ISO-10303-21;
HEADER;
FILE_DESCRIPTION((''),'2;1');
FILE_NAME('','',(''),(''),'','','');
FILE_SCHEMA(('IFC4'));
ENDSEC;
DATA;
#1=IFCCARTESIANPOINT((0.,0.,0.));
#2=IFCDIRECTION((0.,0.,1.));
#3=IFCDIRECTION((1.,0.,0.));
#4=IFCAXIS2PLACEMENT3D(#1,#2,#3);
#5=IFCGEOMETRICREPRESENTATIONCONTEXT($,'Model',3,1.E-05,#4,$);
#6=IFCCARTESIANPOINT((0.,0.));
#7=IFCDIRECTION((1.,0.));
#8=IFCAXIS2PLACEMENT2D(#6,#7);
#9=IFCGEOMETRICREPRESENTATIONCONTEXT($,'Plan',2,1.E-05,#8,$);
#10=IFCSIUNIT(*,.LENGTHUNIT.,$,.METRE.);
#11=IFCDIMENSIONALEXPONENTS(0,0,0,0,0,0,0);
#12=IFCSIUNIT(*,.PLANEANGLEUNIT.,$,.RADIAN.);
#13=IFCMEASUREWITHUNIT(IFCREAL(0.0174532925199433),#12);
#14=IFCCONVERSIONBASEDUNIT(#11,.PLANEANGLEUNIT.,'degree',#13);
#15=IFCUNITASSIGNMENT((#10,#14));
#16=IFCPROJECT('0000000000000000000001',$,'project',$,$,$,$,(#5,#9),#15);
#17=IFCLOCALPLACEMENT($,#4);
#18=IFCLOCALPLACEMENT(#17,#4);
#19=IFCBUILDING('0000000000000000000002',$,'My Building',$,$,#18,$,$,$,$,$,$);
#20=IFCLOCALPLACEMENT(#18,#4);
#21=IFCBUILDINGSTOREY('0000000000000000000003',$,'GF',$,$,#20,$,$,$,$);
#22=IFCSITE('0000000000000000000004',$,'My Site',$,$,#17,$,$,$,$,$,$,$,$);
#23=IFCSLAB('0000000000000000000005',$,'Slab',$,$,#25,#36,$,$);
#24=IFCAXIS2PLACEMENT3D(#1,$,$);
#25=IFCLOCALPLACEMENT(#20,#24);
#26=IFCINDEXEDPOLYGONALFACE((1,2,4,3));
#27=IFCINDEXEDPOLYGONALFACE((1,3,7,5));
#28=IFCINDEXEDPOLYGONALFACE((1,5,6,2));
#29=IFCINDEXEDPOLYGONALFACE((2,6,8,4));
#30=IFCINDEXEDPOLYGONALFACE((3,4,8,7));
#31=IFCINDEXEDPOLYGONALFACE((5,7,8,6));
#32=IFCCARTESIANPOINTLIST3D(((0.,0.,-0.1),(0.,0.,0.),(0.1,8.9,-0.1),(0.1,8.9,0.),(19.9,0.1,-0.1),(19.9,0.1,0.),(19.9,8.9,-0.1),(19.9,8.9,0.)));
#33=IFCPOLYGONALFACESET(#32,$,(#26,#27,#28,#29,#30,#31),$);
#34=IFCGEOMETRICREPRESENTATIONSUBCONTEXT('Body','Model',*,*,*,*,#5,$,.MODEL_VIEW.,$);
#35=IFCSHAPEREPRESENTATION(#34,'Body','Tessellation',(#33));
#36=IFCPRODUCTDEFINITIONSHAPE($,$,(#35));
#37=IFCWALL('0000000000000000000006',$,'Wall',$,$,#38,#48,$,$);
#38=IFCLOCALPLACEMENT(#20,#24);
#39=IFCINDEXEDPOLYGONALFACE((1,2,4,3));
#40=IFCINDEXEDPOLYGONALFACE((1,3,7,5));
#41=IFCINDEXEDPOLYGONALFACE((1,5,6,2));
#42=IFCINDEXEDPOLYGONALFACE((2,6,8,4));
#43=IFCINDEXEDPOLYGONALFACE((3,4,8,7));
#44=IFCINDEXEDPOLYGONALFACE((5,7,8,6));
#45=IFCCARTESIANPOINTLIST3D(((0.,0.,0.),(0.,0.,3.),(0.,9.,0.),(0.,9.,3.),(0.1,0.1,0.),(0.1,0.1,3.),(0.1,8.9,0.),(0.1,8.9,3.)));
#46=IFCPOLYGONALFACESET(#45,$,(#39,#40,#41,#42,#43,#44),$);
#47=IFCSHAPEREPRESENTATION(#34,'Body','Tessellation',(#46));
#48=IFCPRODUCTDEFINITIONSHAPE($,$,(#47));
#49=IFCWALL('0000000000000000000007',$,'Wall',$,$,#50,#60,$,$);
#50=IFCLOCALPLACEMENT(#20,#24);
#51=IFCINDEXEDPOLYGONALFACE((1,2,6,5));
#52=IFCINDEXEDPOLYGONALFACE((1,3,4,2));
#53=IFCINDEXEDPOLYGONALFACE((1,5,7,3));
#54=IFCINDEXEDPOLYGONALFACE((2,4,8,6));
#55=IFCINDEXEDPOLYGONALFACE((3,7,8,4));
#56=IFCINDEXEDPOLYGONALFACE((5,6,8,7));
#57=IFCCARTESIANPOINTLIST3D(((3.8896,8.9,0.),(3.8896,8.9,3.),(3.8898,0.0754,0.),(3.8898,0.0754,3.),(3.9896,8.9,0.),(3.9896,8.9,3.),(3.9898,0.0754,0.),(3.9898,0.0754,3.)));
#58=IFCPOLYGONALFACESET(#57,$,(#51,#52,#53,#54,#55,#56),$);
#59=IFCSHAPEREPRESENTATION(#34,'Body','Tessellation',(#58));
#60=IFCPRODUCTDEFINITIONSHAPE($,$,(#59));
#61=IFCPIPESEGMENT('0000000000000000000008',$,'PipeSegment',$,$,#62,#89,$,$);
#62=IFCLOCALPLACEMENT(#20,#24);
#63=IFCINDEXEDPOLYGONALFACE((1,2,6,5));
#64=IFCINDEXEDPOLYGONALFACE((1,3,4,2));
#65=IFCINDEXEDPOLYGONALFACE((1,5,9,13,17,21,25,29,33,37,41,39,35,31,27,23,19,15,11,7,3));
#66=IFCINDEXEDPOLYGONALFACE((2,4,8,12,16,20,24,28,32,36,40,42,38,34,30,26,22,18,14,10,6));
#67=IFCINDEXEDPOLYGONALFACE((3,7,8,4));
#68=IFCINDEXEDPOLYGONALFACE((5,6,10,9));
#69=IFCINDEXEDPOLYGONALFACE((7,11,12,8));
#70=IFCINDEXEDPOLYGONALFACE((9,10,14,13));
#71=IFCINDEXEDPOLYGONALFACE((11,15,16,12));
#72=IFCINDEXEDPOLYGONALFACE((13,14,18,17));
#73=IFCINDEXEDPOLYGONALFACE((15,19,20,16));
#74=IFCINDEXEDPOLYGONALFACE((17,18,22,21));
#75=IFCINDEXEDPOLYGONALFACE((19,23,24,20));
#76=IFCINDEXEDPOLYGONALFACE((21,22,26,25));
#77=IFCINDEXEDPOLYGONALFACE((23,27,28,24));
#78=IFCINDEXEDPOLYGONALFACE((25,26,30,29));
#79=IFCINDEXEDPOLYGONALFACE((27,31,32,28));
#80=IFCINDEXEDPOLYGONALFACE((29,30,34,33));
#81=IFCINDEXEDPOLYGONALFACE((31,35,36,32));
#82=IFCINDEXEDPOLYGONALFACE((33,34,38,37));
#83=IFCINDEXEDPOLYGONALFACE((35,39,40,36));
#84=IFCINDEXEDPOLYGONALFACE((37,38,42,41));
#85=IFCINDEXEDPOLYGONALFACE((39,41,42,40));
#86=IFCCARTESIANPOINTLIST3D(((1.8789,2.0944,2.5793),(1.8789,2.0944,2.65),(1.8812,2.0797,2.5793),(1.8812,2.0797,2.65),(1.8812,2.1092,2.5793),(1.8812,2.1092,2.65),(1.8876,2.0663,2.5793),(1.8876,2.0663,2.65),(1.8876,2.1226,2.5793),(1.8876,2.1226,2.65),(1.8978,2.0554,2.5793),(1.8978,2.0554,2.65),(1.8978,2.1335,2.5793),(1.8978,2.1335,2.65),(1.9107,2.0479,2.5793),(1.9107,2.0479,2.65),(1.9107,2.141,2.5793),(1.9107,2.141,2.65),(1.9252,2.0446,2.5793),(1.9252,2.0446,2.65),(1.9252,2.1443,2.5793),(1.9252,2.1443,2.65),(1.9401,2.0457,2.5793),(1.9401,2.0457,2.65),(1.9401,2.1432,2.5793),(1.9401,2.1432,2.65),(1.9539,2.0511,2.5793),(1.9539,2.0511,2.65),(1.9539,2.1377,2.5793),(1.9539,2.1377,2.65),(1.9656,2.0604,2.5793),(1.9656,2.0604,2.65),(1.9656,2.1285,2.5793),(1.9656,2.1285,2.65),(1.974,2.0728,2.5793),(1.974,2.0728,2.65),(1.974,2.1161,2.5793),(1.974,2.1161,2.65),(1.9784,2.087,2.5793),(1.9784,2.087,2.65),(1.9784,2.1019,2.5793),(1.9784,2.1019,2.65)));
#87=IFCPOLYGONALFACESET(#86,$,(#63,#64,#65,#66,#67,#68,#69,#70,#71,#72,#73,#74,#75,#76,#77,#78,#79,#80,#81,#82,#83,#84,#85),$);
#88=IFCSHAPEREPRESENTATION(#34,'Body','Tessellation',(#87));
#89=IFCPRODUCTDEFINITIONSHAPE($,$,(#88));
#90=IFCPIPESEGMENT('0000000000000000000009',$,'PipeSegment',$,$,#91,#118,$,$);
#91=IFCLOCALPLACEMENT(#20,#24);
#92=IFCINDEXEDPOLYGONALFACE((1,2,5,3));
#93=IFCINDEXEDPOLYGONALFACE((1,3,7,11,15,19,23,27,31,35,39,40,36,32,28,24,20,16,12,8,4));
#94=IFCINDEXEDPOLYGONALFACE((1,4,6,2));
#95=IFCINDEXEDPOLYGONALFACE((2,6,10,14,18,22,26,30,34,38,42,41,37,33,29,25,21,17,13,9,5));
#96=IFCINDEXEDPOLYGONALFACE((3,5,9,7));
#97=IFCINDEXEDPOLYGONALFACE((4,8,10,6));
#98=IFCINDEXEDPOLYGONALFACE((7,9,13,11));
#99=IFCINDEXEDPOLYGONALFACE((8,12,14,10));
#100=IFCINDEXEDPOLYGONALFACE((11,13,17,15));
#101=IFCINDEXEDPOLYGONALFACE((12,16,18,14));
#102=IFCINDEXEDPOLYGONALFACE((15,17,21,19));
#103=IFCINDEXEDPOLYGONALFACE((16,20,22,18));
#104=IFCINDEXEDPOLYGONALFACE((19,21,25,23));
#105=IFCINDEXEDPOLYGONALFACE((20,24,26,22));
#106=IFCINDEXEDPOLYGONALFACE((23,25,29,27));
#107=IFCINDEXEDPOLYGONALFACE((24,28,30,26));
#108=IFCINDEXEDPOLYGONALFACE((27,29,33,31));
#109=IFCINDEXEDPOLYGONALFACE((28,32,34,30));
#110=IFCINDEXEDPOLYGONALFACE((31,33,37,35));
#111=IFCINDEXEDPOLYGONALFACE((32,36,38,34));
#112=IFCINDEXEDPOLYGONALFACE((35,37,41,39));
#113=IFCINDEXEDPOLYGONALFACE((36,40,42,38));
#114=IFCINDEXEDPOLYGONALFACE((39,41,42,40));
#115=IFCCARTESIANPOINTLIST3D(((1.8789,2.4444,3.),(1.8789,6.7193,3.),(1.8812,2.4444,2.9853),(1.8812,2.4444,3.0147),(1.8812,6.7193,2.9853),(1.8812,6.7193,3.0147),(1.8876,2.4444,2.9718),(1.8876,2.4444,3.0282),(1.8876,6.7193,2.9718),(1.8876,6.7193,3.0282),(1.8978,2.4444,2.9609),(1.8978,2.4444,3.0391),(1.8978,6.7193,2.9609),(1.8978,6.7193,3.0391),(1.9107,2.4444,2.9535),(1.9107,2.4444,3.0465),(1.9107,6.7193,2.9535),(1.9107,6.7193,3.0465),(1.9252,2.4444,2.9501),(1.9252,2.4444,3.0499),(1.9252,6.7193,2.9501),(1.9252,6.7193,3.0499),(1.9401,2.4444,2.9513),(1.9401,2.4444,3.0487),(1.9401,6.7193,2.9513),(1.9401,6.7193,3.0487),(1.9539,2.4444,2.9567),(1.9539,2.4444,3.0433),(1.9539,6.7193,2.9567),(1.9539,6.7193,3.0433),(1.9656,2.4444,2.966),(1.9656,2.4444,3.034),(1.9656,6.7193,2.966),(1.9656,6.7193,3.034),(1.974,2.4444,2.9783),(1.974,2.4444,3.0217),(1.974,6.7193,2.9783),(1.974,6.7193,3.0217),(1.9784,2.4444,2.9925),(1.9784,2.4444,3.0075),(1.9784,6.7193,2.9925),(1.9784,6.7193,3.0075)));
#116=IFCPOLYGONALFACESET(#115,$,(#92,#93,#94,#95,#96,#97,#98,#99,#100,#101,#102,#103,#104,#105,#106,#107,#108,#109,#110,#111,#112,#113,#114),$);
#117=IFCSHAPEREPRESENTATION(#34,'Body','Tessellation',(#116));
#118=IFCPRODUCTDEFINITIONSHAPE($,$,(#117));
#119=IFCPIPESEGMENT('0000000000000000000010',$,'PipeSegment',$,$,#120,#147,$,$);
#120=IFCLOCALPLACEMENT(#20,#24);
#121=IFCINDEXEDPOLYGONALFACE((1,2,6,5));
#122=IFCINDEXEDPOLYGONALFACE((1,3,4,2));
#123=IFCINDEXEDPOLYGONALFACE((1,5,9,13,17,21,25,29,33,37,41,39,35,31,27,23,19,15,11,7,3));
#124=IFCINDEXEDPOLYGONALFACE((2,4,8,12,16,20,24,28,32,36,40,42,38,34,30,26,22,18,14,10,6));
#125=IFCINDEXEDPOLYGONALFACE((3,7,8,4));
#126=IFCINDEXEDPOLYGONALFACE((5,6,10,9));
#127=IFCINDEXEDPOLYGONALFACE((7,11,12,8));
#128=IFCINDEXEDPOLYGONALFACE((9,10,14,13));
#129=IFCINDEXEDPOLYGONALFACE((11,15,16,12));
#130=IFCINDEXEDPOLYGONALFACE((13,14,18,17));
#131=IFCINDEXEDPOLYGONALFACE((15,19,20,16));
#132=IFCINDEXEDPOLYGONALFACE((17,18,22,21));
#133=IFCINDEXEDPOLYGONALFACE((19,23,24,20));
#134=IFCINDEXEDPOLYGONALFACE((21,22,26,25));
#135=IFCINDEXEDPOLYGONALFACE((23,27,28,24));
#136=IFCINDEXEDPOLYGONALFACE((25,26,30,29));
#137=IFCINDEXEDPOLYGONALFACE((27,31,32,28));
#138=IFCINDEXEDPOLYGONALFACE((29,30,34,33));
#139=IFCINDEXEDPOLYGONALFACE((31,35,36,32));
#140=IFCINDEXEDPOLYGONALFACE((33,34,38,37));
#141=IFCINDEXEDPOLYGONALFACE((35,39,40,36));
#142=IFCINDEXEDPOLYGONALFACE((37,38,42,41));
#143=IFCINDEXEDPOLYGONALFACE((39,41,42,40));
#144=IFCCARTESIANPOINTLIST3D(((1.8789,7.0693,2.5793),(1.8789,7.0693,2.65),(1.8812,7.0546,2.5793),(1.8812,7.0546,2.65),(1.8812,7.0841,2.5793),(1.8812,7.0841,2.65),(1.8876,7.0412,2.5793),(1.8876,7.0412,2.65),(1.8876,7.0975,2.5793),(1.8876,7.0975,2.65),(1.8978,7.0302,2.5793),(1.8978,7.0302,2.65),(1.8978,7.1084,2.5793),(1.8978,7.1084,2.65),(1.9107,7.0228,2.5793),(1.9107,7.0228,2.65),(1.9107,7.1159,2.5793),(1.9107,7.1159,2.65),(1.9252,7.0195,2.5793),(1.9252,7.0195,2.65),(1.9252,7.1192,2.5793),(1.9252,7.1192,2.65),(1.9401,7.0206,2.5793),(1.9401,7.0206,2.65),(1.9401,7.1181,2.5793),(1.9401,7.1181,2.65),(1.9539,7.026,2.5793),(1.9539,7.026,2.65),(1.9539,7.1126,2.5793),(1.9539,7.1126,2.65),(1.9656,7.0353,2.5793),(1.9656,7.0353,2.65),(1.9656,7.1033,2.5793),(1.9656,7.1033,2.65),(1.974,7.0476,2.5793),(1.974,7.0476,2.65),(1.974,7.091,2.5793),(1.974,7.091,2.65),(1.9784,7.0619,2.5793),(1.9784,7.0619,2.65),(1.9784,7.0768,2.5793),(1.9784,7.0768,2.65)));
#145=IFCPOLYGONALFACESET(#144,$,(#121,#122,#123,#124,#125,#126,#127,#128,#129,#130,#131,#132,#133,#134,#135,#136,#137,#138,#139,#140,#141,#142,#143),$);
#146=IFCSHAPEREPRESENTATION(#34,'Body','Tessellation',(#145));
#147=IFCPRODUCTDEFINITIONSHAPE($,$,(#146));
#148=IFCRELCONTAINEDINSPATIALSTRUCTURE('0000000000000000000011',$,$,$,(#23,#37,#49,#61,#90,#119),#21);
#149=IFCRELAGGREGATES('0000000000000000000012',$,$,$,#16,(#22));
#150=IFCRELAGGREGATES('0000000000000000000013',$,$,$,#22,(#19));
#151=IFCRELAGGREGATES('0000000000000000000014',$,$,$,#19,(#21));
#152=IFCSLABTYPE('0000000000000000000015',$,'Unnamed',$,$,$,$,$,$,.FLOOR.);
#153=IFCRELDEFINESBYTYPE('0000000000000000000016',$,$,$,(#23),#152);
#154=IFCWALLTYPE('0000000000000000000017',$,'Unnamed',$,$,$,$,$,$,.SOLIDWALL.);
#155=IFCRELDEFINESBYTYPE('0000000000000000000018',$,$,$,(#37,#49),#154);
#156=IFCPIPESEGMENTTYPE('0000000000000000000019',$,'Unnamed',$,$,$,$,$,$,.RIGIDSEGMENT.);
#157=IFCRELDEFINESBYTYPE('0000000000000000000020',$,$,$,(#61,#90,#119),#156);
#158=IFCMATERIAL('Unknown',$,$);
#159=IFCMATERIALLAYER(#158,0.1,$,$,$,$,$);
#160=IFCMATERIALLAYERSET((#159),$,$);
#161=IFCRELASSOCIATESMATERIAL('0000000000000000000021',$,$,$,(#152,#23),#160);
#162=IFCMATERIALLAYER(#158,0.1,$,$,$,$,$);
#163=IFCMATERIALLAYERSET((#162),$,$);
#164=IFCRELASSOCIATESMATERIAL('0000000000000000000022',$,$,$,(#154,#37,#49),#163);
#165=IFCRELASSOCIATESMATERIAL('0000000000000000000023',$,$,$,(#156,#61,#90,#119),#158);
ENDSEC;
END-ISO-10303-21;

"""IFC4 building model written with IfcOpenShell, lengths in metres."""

from ifc_helpers import new_model, entity, si_unit, converted_unit, frame, origin_with_axes, origin_2d_with_axis, place, context, subcontext, project, spatial, line, indexed_curve, circle, outline, extrude, material, layer, layer_set, layer_usage, material_profile, profile_set, profile_usage, type_object, element, save


model = new_model("IFC4")

# Units and contexts
model_context = context("Model", 3, precision=1e-05, world=origin_with_axes())
plan_context = context("Plan", 2, precision=1e-05, world=origin_2d_with_axis())
body_context_1 = subcontext(model_context, "Body", "Model", "MODEL_VIEW")
ifc_project = project(units=[si_unit("LENGTHUNIT", "METRE"), converted_unit("PLANEANGLEUNIT", "degree", entity("IfcReal", 0.0174532925199433), si_unit("PLANEANGLEUNIT", "RADIAN"), dimensions=[0, 0, 0, 0, 0, 0, 0])], contexts=[model_context, plan_context])

# Site, building, storey
site_placement = place(None, origin_with_axes())
site = spatial("IfcSite", under=ifc_project, at=site_placement, Name="My Site")
building_placement = place(site_placement, origin_with_axes())
building = spatial("IfcBuilding", under=site, at=building_placement, Name="My Building")
storey_placement = place(building_placement, origin_with_axes())
storey = spatial("IfcBuildingStorey", under=building, at=storey_placement, Name="GF")

# Slab
ifc_material = material(Name="Unknown")
ifc_layer_1 = layer(ifc_material, 0.1)
ifc_layer_set_1 = layer_set([ifc_layer_1])
ifc_layer_usage_1 = layer_usage(ifc_layer_set_1, "AXIS3", "POSITIVE", -0.1)
slab_type = type_object("IfcSlabType", Name="Unnamed", PredefinedType="FLOOR", material=ifc_layer_set_1)
slab_placement = place(storey_placement, frame((0.1, 8.9, 0.0), z_axis=(0.0, 0.0, 1.0), x_axis=(1.0, 0.0, 0.0)))
element("IfcSlab", 1, at=slab_placement, inside=storey, type_object=slab_type, material=ifc_layer_usage_1, Name="Slab", context=body_context_1, shape_type="SweptSolid", body=[
    extrude(outline(indexed_curve([(0.0, 0.0), (19.8, 0.0), (19.8, -8.8), (-0.1, -8.9), (0.0, 0.0)])), frame((0.0, 0.0, -0.1), z_axis=(0.0, 0.0, 1.0), x_axis=(1.0, 0.0, 0.0)), (0.0, 0.0, 1.0), 0.1),
])

# Shared definitions
ifc_layer_2 = layer(ifc_material, 0.1)
ifc_layer_set_2 = layer_set([ifc_layer_2])
wall_type = type_object("IfcWallType", Name="Unnamed", PredefinedType="SOLIDWALL", material=ifc_layer_set_2)

# Walls
ifc_layer_usage_2 = layer_usage(ifc_layer_set_2, "AXIS2", "POSITIVE", 0.0)
wall_1_placement = place(storey_placement, frame((0.0, 9.0, 0.0), z_axis=(0.0, 0.0, 1.0), x_axis=(0.0, -1.0, 0.0)))
element("IfcWall", 2, at=wall_1_placement, inside=storey, type_object=wall_type, material=ifc_layer_usage_2, Name="Wall", context=body_context_1, shape_type="SweptSolid", body=[
    extrude(outline(indexed_curve([(0.0, 0.0), (0.1, 0.1), (8.9, 0.1), (9.0, 0.0)], segments=[line(1, 2, 3, 4, 1)])), origin_with_axes(), (0.0, 0.0, 1.0), 3.0),
])
ifc_layer_usage_3 = layer_usage(ifc_layer_set_2, "AXIS2", "POSITIVE", 0.0)
wall_2_placement = place(storey_placement, frame((3.9898, 0.0754, 0.0), z_axis=(0.0, 0.0, 1.0), x_axis=(-0.000021, 1.0, 0.0)))
element("IfcWall", 3, at=wall_2_placement, inside=storey, type_object=wall_type, material=ifc_layer_usage_3, Name="Wall", context=body_context_1, shape_type="SweptSolid", body=[
    extrude(outline(indexed_curve([(0.0, 0.0), (0.0, 0.1), (8.8246, 0.1), (8.8246, 0.0)], segments=[line(1, 2, 3, 4, 1)])), origin_with_axes(), (0.0, 0.0, 1.0), 3.0),
])

# Pipe segments
ifc_material_profile = material_profile(ifc_material, circle(Radius=0.05))
ifc_profile_set = profile_set([ifc_material_profile])
ifc_profile_usage_1 = profile_usage(ifc_profile_set, cardinal=5)
pipe_segment_type = type_object("IfcPipeSegmentType", Name="Unnamed", PredefinedType="RIGIDSEGMENT", material=ifc_profile_set)
pipe_segment_1_placement = place(storey_placement, frame((1.9289, 2.0944, 2.65), z_axis=(0.0, 0.0, -1.0), x_axis=(-1.0, 0.0, 0.0)))
element("IfcPipeSegment", 4, at=pipe_segment_1_placement, inside=storey, type_object=pipe_segment_type, material=ifc_profile_usage_1, Name="PipeSegment", context=body_context_1, shape_type="SweptSolid", body=[
    extrude(circle(Radius=0.05), origin_with_axes(), (0.0, 0.0, 1.0), 0.0707),
])
ifc_profile_usage_2 = profile_usage(ifc_profile_set, cardinal=5)
pipe_segment_2_placement = place(storey_placement, frame((1.9289, 2.4444, 3.0), z_axis=(0.0, 1.0, 0.0), x_axis=(-1.0, 0.0, 0.0)))
element("IfcPipeSegment", 5, at=pipe_segment_2_placement, inside=storey, type_object=pipe_segment_type, material=ifc_profile_usage_2, Name="PipeSegment", context=body_context_1, shape_type="SweptSolid", body=[
    extrude(circle(Radius=0.05), origin_with_axes(), (0.0, 0.0, 1.0), 4.2749),
])
ifc_profile_usage_3 = profile_usage(ifc_profile_set, cardinal=5)
pipe_segment_3_placement = place(storey_placement, frame((1.9289, 7.0693, 2.65), z_axis=(0.0, 0.0, -1.0), x_axis=(-1.0, 0.0, 0.0)))
element("IfcPipeSegment", 6, at=pipe_segment_3_placement, inside=storey, type_object=pipe_segment_type, material=ifc_profile_usage_3, Name="PipeSegment", context=body_context_1, shape_type="SweptSolid", body=[
    extrude(circle(Radius=0.05), origin_with_axes(), (0.0, 0.0, 1.0), 0.0707),
])

save(model, "model.ifc")
